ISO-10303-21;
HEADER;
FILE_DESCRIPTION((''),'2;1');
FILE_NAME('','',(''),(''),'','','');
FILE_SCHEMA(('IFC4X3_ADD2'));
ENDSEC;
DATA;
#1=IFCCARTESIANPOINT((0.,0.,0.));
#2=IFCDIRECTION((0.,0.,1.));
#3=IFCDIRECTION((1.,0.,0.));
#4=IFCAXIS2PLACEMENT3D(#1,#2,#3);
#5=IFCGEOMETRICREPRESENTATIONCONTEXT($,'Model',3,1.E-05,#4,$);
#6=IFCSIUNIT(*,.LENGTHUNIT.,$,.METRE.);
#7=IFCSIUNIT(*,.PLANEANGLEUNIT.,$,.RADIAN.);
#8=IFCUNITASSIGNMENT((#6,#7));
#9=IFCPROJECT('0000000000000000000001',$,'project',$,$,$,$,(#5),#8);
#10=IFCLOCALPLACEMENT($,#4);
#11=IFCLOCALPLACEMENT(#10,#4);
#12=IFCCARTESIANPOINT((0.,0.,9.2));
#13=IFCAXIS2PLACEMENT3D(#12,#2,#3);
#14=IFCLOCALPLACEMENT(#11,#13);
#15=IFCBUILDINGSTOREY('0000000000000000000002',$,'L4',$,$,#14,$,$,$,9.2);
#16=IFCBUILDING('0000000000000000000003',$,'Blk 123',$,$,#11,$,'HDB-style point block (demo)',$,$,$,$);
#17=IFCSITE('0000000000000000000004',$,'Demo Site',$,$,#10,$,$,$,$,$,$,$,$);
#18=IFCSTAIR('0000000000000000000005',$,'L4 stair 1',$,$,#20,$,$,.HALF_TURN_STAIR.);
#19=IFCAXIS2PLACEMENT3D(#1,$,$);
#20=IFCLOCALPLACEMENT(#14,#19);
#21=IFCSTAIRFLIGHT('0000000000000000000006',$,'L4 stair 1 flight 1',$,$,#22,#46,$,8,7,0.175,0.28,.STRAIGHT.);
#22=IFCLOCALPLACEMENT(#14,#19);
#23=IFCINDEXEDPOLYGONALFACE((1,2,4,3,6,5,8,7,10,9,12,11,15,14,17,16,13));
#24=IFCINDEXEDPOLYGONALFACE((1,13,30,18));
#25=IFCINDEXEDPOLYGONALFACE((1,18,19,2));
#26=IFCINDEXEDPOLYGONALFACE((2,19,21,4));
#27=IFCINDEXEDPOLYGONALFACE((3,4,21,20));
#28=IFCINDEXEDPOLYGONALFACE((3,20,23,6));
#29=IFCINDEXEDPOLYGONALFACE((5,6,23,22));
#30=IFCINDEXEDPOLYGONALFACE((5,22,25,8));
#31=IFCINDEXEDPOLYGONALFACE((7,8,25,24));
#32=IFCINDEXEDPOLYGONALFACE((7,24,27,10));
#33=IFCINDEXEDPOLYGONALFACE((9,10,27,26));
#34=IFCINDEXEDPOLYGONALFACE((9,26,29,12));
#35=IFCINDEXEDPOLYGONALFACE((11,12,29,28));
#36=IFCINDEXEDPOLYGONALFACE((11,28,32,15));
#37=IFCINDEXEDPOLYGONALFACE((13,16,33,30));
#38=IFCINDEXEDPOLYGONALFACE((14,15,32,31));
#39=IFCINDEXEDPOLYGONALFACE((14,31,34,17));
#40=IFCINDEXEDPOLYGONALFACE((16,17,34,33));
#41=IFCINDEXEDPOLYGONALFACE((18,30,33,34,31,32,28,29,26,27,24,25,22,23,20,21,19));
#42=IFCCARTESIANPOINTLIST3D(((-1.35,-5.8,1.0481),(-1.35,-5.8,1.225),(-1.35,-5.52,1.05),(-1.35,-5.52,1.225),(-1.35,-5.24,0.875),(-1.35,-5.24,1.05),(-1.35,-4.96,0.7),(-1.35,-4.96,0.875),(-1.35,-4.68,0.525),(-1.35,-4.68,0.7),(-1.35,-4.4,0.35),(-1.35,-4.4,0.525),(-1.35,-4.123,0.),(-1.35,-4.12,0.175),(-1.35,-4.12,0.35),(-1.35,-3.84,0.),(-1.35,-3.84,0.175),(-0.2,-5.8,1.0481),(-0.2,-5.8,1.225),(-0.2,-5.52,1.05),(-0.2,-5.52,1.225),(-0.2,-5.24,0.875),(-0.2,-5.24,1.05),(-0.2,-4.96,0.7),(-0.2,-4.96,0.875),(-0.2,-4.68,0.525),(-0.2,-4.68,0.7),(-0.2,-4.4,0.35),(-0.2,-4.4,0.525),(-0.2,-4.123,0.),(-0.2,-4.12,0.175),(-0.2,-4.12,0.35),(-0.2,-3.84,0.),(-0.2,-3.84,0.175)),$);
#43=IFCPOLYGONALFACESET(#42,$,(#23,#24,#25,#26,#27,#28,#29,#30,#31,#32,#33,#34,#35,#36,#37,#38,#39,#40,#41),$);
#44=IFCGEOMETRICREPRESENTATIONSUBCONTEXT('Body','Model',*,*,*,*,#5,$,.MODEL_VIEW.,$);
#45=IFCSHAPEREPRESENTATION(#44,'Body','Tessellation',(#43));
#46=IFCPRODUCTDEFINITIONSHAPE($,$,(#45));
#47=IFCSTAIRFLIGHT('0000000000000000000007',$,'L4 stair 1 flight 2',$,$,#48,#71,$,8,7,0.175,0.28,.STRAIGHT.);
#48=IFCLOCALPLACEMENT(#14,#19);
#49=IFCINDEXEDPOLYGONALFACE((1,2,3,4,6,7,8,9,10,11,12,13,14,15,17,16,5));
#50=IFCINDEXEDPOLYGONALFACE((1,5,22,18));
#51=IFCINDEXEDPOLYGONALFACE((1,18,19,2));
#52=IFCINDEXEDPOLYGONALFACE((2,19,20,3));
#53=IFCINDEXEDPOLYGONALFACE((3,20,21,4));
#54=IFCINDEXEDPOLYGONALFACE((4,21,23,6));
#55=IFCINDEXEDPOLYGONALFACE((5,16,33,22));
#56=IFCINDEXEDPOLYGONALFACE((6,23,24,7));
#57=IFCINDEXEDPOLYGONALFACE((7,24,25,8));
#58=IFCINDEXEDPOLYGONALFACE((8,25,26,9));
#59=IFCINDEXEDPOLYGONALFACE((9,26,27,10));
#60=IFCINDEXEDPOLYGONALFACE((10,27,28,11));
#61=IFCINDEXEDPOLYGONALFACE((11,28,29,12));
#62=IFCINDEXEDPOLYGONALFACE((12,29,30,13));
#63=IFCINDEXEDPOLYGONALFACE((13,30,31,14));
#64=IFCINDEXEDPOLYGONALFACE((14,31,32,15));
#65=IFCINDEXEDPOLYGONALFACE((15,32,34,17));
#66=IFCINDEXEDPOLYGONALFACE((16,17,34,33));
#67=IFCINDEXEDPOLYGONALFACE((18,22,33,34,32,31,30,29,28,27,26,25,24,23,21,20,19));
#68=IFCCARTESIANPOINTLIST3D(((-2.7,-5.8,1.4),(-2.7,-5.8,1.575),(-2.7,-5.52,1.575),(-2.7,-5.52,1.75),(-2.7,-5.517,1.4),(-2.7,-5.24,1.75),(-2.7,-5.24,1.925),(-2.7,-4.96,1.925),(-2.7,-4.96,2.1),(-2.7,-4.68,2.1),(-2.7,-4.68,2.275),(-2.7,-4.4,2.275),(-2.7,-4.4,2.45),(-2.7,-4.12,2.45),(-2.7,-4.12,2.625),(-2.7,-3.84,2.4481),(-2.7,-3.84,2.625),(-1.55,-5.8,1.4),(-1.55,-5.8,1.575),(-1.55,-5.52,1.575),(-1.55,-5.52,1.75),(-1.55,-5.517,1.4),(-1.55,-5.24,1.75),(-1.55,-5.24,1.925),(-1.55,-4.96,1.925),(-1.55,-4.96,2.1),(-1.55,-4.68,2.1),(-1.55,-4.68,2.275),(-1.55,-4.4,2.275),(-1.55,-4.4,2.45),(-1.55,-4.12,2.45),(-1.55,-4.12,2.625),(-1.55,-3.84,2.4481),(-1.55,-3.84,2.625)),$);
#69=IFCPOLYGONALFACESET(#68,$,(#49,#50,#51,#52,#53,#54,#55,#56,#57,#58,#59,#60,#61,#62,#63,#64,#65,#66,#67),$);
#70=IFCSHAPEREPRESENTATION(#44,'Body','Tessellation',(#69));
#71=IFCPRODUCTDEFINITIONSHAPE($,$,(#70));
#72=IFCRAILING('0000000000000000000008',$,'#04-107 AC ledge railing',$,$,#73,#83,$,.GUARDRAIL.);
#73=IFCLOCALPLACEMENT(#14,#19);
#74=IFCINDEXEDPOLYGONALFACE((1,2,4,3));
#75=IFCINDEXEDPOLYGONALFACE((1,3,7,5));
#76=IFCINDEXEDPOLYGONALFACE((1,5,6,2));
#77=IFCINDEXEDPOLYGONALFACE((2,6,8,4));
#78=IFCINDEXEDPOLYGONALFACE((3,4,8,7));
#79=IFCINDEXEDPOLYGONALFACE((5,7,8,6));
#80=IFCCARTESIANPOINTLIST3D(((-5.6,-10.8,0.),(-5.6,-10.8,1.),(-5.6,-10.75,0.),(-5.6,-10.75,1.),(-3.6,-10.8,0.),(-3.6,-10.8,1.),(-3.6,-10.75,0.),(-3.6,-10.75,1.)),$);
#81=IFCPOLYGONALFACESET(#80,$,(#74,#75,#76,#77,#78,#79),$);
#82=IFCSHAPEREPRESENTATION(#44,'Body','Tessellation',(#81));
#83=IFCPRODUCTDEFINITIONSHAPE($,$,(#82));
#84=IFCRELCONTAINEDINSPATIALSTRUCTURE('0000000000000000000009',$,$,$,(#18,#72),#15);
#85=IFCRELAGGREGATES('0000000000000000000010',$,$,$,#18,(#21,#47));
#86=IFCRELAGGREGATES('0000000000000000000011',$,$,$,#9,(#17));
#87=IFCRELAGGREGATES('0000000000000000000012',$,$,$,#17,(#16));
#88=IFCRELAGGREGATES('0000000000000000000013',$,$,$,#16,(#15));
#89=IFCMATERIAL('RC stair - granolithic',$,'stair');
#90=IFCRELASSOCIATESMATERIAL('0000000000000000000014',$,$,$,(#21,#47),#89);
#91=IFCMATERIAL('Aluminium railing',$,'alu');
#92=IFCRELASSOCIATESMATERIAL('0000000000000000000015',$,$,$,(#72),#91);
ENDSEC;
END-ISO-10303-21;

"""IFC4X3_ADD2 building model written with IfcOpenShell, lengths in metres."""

from ifc_helpers import new_model, si_unit, frame, origin, origin_with_axes, place, context, subcontext, project, spatial, polyline, outline, extrude, material, element, aggregate, save


model = new_model("IFC4X3_ADD2")

# Units and contexts
model_context = context("Model", 3, precision=1e-05, world=origin_with_axes())
body_context = subcontext(model_context, "Body", "Model", "MODEL_VIEW")
ifc_project = project(units=[si_unit("LENGTHUNIT", "METRE"), si_unit("PLANEANGLEUNIT", "RADIAN")], contexts=[model_context])

# Site, building, storey
site_placement = place(None, origin_with_axes())
site = spatial("IfcSite", under=ifc_project, at=site_placement, Name="Demo Site")
building_placement = place(site_placement, origin_with_axes())
building = spatial("IfcBuilding", under=site, at=building_placement, Name="Blk 123", LongName="HDB-style point block (demo)")
storey_placement = place(building_placement, frame((0.0, 0.0, 9.2), z_axis=(0.0, 0.0, 1.0), x_axis=(1.0, 0.0, 0.0)))
storey = spatial("IfcBuildingStorey", under=building, at=storey_placement, Name="L4", Elevation=9.2)

# Stair
stair_placement = place(storey_placement, frame((-2.7, -7.1, 0.0), z_axis=(0.0, 0.0, 1.0), x_axis=(1.0, 0.0, 0.0)))
stair = element("IfcStair", 1, at=stair_placement, inside=storey, Name="L4 stair 1", PredefinedType="HALF_TURN_STAIR")
ifc_material_1 = material(Name="RC stair - granolithic", Category="stair")

# Stair flights
stair_flight_1_placement = place(stair_placement, frame((2.5, 3.26, 0.0), z_axis=(0.0, 0.0, 1.0), x_axis=(1.0, 0.0, 0.0)))
stair_flight_1 = element("IfcStairFlight", 2, at=stair_flight_1_placement, material=ifc_material_1, Name="L4 stair 1 flight 1", NumberOfRisers=8, NumberOfTreads=7, PredefinedType="STRAIGHT", RiserHeight=0.175, TreadLength=0.28, context=body_context, shape_type="SweptSolid", body=[
    extrude(outline(polyline([(0.0, 0.0), (0.0, 0.175), (0.28, 0.175), (0.28, 0.35), (0.56, 0.35), (0.56, 0.525), (0.84, 0.525), (0.84, 0.7), (1.12, 0.7), (1.12, 0.875), (1.4, 0.875), (1.4, 1.05), (1.68, 1.05), (1.68, 1.225), (1.96, 1.225), (1.96, 1.4), (1.96, 1.0481), (0.283, 0.0), (0.0, 0.0)])), frame((0.0, 0.0, 0.0), z_axis=(-1.0, 0.0, 0.0), x_axis=(0.0, -1.0, 0.0)), (0.0, 0.0, 1.0), 1.15),
])
stair_flight_2_placement = place(stair_placement, frame((0.0, 1.3, 1.4), z_axis=(0.0, 0.0, 1.0), x_axis=(1.0, 0.0, 0.0)))
stair_flight_2 = element("IfcStairFlight", 3, at=stair_flight_2_placement, material=ifc_material_1, Name="L4 stair 1 flight 2", NumberOfRisers=8, NumberOfTreads=7, PredefinedType="STRAIGHT", RiserHeight=0.175, TreadLength=0.28, context=body_context, shape_type="SweptSolid", body=[
    extrude(outline(polyline([(0.0, 0.0), (0.0, 0.175), (0.28, 0.175), (0.28, 0.35), (0.56, 0.35), (0.56, 0.525), (0.84, 0.525), (0.84, 0.7), (1.12, 0.7), (1.12, 0.875), (1.4, 0.875), (1.4, 1.05), (1.68, 1.05), (1.68, 1.225), (1.96, 1.225), (1.96, 1.4), (1.96, 1.0481), (0.283, 0.0), (0.0, 0.0)])), frame((0.0, 0.0, 0.0), z_axis=(1.0, 0.0, 0.0), x_axis=(0.0, 1.0, 0.0)), (0.0, 0.0, 1.0), 1.15),
])

# Railing
aggregate(stair, [stair_flight_1, stair_flight_2])
ifc_material_2 = material(Name="Aluminium railing", Category="alu")
railing_1_placement = place(storey_placement, frame((-4.6, -10.775, 0.0), z_axis=(0.0, 0.0, 1.0), x_axis=(1.0, 0.0, 0.0)))
element("IfcRailing", 4, at=railing_1_placement, inside=storey, material=ifc_material_2, Name="#04-107 AC ledge railing", PredefinedType="GUARDRAIL", context=body_context, shape_type="SweptSolid", body=[
    extrude(outline(polyline([(-1.0, 0.025), (-1.0, -0.025), (1.0, -0.025), (1.0, 0.025), (-1.0, 0.025)])), origin(), (0.0, 0.0, 1.0), 1.0),
])

save(model, "model.ifc")
